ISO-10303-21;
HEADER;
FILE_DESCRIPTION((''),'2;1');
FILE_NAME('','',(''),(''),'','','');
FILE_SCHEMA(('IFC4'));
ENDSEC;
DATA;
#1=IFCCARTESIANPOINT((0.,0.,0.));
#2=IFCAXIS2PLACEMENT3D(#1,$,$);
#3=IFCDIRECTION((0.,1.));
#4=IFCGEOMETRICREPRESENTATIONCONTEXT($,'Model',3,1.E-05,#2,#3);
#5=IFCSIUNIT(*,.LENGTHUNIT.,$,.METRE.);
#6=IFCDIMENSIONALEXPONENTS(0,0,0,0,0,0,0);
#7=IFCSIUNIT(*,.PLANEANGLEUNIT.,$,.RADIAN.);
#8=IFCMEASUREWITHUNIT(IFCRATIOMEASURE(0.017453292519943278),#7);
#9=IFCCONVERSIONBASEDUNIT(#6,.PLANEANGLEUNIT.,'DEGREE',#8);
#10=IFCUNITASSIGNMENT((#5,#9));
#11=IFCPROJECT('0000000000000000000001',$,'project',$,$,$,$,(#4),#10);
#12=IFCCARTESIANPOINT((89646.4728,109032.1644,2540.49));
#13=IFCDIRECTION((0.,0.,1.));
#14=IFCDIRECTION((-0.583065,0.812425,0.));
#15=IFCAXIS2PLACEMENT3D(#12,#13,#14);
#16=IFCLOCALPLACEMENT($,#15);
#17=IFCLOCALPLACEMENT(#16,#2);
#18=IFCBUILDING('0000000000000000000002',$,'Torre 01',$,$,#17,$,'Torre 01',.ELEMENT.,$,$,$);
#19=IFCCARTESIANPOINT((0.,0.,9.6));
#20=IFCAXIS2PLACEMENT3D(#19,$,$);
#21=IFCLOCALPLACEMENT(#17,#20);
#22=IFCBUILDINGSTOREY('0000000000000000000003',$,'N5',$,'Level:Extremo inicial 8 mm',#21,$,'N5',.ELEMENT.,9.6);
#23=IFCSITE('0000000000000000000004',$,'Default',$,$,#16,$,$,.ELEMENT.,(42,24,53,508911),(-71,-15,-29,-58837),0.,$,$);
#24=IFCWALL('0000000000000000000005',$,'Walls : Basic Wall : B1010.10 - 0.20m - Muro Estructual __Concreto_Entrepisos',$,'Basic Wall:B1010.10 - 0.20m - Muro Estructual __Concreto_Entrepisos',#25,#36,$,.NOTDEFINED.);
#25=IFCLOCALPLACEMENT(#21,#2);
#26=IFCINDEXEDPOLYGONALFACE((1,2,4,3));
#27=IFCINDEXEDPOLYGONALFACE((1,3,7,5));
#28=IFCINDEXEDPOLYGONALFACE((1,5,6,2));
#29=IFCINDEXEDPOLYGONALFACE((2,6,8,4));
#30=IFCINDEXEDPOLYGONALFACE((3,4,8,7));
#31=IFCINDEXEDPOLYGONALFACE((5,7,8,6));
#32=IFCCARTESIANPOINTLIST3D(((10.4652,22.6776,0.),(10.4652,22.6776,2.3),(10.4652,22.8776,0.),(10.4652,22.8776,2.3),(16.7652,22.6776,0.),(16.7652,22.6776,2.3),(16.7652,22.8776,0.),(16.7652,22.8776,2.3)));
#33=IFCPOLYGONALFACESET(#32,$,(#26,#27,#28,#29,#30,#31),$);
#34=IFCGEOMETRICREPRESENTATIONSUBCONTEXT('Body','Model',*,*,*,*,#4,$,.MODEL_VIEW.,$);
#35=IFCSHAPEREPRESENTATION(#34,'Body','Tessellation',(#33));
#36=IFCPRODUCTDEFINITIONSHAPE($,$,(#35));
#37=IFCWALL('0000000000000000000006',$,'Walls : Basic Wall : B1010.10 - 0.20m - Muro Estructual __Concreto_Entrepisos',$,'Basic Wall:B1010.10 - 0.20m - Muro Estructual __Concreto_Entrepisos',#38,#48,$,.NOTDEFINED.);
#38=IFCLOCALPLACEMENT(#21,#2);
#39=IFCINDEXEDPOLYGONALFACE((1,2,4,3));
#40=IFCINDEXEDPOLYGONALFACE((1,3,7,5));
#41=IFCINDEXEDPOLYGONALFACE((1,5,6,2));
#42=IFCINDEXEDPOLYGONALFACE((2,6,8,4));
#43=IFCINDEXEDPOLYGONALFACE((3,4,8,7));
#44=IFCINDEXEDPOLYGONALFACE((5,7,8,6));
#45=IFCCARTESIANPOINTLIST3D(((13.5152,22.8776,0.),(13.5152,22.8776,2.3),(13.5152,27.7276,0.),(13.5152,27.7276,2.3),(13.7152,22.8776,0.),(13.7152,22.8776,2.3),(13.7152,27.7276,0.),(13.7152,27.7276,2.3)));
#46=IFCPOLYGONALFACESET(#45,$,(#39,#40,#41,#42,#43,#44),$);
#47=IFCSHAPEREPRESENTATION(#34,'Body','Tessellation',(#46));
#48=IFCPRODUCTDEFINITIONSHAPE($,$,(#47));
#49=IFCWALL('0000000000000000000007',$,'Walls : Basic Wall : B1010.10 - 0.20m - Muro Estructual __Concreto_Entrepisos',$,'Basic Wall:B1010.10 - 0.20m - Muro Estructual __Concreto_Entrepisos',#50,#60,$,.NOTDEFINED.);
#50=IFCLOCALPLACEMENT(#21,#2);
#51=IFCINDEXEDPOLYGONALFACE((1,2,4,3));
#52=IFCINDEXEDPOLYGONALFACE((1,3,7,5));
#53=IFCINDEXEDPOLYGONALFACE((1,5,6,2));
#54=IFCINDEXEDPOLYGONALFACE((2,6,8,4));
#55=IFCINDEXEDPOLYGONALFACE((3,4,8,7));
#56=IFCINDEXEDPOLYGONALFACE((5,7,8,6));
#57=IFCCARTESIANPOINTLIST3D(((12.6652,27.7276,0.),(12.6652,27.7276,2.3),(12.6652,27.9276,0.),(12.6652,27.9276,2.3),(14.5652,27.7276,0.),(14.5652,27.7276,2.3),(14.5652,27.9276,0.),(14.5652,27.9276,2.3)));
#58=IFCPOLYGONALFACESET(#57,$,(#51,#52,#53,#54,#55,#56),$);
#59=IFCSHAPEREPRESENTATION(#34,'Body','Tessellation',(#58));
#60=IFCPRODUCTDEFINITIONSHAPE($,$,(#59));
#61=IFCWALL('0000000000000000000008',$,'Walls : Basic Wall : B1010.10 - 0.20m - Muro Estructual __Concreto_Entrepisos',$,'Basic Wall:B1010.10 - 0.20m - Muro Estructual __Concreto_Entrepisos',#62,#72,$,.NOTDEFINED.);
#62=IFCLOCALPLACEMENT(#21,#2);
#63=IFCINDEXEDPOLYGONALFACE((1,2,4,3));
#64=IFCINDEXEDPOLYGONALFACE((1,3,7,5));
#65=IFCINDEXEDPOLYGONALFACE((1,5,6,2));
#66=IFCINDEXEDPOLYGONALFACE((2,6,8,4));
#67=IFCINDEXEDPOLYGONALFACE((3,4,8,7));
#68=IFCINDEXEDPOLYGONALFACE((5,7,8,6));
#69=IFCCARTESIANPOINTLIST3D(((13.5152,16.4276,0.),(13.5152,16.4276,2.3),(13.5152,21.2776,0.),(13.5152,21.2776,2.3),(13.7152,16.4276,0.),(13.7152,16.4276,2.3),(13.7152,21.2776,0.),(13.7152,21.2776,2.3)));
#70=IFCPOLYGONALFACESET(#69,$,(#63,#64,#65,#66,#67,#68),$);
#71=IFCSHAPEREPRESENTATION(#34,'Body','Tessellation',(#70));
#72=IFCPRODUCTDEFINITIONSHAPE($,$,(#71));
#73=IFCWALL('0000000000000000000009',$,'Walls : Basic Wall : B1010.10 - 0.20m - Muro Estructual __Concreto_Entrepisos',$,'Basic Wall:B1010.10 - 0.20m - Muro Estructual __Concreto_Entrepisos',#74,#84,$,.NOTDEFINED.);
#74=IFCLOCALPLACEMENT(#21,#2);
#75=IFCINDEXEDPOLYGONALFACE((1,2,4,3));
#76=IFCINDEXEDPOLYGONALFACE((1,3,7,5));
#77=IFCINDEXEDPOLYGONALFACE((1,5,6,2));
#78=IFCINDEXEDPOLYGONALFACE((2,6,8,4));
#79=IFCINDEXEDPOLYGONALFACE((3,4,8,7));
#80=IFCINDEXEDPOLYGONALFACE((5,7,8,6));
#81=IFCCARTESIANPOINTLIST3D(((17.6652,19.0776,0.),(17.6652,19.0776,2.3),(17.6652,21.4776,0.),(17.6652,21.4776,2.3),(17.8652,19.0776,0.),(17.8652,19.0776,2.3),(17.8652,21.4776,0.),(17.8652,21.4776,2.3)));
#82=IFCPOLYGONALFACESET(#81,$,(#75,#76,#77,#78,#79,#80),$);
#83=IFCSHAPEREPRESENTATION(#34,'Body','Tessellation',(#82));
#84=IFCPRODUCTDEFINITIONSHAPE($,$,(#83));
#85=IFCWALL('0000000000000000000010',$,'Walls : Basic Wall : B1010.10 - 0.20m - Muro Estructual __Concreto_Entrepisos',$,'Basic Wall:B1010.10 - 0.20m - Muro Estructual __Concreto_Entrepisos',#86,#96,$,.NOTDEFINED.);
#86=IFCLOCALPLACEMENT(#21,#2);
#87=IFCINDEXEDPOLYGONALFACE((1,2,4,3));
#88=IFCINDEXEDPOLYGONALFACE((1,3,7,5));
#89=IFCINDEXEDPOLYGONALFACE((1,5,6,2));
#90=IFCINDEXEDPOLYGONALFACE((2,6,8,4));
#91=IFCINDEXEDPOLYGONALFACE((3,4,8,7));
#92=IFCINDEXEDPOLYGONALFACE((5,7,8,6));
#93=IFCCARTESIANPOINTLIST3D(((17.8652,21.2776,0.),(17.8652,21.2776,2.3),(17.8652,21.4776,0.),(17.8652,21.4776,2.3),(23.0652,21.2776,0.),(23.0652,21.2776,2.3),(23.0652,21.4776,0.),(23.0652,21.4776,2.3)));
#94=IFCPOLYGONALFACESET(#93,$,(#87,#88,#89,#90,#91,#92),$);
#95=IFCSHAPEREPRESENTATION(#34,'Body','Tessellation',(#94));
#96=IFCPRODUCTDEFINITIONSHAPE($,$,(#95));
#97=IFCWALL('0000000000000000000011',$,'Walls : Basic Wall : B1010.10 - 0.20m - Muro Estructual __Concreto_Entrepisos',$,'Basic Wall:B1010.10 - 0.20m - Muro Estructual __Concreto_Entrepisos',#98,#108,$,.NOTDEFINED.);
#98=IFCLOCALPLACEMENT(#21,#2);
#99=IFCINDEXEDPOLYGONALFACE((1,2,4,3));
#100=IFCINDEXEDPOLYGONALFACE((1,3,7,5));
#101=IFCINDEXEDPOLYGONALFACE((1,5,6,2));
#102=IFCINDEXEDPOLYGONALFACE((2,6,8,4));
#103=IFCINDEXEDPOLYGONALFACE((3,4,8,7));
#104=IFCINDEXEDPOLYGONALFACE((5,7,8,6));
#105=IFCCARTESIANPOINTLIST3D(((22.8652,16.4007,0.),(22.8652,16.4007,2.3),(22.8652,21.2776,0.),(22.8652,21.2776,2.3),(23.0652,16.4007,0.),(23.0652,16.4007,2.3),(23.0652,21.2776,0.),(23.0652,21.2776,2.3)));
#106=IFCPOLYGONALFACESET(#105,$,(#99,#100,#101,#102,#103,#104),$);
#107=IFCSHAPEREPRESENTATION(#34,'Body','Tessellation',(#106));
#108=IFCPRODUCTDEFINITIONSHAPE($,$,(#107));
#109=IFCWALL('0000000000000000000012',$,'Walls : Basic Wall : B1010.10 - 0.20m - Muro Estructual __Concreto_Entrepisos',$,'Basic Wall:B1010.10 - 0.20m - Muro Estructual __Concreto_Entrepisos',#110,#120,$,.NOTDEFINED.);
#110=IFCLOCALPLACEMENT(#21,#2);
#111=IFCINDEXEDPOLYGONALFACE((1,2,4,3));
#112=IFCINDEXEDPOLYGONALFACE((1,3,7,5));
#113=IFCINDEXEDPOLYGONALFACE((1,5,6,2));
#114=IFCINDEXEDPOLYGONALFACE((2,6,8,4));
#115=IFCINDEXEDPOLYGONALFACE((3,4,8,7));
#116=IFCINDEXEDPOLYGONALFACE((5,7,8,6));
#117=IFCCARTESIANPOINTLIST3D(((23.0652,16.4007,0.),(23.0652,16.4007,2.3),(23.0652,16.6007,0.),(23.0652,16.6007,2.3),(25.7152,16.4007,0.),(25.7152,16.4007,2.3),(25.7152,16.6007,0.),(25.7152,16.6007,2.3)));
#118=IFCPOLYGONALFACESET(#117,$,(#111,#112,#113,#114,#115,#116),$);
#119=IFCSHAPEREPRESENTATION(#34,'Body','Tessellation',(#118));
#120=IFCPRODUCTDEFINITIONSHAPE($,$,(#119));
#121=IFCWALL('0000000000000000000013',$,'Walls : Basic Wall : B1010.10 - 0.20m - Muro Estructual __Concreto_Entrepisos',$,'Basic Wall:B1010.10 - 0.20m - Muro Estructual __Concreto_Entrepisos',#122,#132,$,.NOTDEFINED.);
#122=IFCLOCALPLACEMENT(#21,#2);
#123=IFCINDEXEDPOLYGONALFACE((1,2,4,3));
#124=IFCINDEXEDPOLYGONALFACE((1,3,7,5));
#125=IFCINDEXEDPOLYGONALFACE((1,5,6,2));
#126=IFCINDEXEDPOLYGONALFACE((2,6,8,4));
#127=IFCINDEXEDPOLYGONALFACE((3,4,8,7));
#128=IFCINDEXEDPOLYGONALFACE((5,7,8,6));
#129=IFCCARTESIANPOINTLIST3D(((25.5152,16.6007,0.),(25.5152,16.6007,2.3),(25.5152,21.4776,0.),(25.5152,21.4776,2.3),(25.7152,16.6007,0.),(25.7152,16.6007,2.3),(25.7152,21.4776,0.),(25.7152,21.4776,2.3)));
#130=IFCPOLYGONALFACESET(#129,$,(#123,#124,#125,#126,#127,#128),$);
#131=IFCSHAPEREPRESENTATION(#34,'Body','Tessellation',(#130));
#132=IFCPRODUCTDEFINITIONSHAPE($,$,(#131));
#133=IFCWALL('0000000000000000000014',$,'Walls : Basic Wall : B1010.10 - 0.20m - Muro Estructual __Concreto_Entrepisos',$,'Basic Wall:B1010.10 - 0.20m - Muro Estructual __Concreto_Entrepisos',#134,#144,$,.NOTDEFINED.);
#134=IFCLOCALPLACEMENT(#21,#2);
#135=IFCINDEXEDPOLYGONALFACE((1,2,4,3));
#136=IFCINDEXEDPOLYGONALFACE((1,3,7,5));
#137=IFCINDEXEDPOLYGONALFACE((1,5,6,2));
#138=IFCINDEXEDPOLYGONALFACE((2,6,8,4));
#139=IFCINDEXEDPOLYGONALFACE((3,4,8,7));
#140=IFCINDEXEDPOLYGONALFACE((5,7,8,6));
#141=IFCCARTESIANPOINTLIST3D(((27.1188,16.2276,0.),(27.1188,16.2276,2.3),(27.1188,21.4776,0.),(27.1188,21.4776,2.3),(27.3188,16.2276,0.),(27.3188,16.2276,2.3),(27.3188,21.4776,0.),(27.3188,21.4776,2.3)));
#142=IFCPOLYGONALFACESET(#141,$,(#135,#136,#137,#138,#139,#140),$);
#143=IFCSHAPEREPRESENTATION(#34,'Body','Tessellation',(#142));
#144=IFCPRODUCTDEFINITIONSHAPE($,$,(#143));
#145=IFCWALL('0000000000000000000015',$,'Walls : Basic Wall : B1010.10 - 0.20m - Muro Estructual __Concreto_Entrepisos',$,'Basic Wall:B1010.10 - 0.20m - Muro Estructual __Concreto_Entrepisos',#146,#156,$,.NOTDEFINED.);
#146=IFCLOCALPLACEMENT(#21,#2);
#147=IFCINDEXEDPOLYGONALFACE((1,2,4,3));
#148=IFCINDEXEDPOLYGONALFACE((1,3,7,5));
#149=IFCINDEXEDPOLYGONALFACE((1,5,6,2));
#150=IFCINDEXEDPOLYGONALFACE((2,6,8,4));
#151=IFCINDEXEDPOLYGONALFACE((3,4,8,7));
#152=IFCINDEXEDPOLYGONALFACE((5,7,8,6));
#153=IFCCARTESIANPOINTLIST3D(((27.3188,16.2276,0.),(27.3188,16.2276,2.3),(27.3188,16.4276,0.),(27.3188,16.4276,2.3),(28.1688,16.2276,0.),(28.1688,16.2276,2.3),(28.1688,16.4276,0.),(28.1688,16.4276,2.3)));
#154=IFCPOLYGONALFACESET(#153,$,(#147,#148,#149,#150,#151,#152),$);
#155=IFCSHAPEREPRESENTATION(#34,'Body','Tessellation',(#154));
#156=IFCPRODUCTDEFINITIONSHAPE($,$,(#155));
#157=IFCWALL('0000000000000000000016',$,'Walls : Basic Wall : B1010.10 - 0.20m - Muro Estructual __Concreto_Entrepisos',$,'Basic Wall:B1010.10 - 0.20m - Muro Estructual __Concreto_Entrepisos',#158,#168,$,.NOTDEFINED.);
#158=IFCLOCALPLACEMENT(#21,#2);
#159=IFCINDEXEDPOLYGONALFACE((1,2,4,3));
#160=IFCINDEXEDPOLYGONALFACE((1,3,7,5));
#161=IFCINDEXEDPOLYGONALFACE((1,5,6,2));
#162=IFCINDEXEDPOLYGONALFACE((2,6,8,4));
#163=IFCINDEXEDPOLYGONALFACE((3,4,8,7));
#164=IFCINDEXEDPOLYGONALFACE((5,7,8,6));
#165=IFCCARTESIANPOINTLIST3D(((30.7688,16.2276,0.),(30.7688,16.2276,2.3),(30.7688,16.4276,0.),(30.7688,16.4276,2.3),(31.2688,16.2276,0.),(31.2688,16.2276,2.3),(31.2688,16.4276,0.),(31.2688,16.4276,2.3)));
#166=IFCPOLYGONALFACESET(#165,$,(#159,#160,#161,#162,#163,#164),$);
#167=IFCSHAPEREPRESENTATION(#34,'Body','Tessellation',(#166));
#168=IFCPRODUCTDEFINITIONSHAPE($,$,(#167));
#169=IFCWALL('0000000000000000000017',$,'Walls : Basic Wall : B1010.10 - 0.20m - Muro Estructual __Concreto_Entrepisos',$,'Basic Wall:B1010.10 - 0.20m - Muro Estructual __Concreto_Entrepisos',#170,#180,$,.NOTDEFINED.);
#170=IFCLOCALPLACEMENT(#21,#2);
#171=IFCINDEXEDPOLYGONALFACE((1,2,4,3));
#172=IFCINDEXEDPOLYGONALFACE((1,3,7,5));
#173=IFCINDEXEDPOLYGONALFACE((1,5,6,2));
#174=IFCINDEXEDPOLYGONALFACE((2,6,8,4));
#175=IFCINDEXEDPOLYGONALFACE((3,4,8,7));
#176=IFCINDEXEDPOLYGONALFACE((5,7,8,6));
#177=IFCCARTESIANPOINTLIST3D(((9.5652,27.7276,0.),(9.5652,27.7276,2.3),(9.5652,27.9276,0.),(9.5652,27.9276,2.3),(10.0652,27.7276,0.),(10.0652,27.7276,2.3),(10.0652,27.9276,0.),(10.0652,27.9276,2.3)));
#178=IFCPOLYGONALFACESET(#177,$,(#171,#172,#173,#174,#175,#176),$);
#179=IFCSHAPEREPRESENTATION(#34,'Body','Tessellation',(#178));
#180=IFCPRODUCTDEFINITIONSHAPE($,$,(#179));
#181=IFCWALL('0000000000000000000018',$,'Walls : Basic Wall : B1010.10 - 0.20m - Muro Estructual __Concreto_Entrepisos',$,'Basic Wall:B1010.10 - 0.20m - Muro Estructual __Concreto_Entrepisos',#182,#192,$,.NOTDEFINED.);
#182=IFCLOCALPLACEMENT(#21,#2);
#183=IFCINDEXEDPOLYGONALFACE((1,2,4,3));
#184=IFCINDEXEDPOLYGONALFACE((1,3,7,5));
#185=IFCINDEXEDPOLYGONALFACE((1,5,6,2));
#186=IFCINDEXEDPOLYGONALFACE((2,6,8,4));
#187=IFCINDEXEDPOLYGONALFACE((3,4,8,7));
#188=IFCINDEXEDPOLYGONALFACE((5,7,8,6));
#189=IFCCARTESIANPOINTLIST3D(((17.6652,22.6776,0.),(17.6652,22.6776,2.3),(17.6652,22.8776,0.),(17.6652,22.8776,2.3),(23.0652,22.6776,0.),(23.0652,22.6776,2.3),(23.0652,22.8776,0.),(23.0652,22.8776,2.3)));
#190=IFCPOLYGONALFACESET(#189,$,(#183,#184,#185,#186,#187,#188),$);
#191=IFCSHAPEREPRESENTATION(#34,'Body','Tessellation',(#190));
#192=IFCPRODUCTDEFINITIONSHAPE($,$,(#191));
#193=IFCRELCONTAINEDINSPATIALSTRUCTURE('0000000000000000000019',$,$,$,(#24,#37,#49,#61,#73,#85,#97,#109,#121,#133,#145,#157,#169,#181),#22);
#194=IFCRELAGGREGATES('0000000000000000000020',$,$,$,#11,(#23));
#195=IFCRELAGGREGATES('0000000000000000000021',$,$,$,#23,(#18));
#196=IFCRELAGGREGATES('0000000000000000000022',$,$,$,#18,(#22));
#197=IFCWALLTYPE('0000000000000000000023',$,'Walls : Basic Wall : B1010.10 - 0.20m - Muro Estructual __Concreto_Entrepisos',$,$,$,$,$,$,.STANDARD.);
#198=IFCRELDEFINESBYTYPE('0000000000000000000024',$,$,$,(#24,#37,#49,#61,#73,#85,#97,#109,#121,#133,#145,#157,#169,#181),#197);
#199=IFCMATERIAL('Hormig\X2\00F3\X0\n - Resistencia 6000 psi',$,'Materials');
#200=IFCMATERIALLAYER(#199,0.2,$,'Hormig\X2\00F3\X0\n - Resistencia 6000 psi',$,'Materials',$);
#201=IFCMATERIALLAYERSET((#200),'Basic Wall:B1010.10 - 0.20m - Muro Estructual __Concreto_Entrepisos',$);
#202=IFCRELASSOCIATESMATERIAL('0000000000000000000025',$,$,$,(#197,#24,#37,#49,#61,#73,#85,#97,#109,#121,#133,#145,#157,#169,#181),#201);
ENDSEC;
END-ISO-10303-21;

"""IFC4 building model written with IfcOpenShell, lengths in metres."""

from ifc_helpers import new_model, entity, si_unit, converted_unit, direction, frame, frame_2d, origin, place, context, subcontext, project, spatial, rectangle, extrude, material, layer, layer_set, layer_usage, type_object, element, save


model = new_model("IFC4")

# Units and contexts
model_context = context("Model", 3, precision=1e-05, world=origin(), true_north=direction((0.0, 1.0)))
body_context = subcontext(model_context, "Body", "Model", "MODEL_VIEW")
ifc_project = project(units=[si_unit("LENGTHUNIT", "METRE"), converted_unit("PLANEANGLEUNIT", "DEGREE", entity("IfcRatioMeasure", 0.017453292519943278), si_unit("PLANEANGLEUNIT", "RADIAN"), dimensions=[0, 0, 0, 0, 0, 0, 0])], contexts=[model_context])

# Site, building, storey
site_placement = place(None, frame((89646.4728, 109032.1644, 2540.49), z_axis=(0.0, 0.0, 1.0), x_axis=(-0.583065, 0.812425, 0.0)))
site = spatial("IfcSite", under=ifc_project, at=site_placement, Name="Default", CompositionType="ELEMENT", RefLatitude=(42, 24, 53, 508911), RefLongitude=(-71, -15, -29, -58837), RefElevation=0.0)
building_placement = place(site_placement, origin())
building = spatial("IfcBuilding", under=site, at=building_placement, Name="Torre 01", LongName="Torre 01", CompositionType="ELEMENT")
storey_placement = place(building_placement, frame((0.0, 0.0, 9.6)))
storey = spatial("IfcBuildingStorey", under=building, at=storey_placement, Name="N5", ObjectType="Level:Extremo inicial 8 mm", LongName="N5", CompositionType="ELEMENT", Elevation=9.6)

# Walls
ifc_material = material(Name="Hormigón - Resistencia 6000 psi", Category="Materials")
ifc_layer_1 = layer(ifc_material, 0.2, Name="Hormigón - Resistencia 6000 psi", Category="Materials")
ifc_layer_set_1 = layer_set([ifc_layer_1], Name="Basic Wall:B1010.10 - 0.20m - Muro Estructual __Concreto_Entrepisos")
ifc_layer_usage_1 = layer_usage(ifc_layer_set_1, "AXIS2", "NEGATIVE", 0.1)
wall_type_1 = type_object("IfcWallType", Name="Walls : Basic Wall : B1010.10 - 0.20m - Muro Estructual __Concreto_Entrepisos", PredefinedType="STANDARD", material=ifc_layer_set_1)
wall_1_placement = place(storey_placement, frame((10.4652, 22.7776, 0.0)))
element("IfcWall", 1, at=wall_1_placement, inside=storey, type_object=wall_type_1, material=ifc_layer_usage_1, Name="Walls : Basic Wall : B1010.10 - 0.20m - Muro Estructual __Concreto_Entrepisos", ObjectType="Basic Wall:B1010.10 - 0.20m - Muro Estructual __Concreto_Entrepisos", PredefinedType="NOTDEFINED", context=body_context, shape_type="SweptSolid", body=[
    extrude(rectangle(XDim=6.3, YDim=0.2, at=frame_2d((3.15, 0.0), x_axis=(-1.0, 0.0))), origin(), (0.0, 0.0, 1.0), 2.3),
])
ifc_layer_usage_2 = layer_usage(ifc_layer_set_1, "AXIS2", "NEGATIVE", 0.1)
wall_2_placement = place(storey_placement, frame((13.6152, 22.8776, 0.0), z_axis=(0.0, 0.0, 1.0), x_axis=(0.0, 1.0, 0.0)))
element("IfcWall", 2, at=wall_2_placement, inside=storey, type_object=wall_type_1, material=ifc_layer_usage_2, Name="Walls : Basic Wall : B1010.10 - 0.20m - Muro Estructual __Concreto_Entrepisos", ObjectType="Basic Wall:B1010.10 - 0.20m - Muro Estructual __Concreto_Entrepisos", PredefinedType="NOTDEFINED", context=body_context, shape_type="SweptSolid", body=[
    extrude(rectangle(XDim=4.85, YDim=0.2, at=frame_2d((2.425, 0.0), x_axis=(-1.0, 0.0))), origin(), (0.0, 0.0, 1.0), 2.3),
])
ifc_layer_usage_3 = layer_usage(ifc_layer_set_1, "AXIS2", "NEGATIVE", 0.1)
wall_3_placement = place(storey_placement, frame((12.6652, 27.8276, 0.0)))
element("IfcWall", 3, at=wall_3_placement, inside=storey, type_object=wall_type_1, material=ifc_layer_usage_3, Name="Walls : Basic Wall : B1010.10 - 0.20m - Muro Estructual __Concreto_Entrepisos", ObjectType="Basic Wall:B1010.10 - 0.20m - Muro Estructual __Concreto_Entrepisos", PredefinedType="NOTDEFINED", context=body_context, shape_type="SweptSolid", body=[
    extrude(rectangle(XDim=1.9, YDim=0.2, at=frame_2d((0.95, 0.0), x_axis=(-1.0, 0.0))), origin(), (0.0, 0.0, 1.0), 2.3),
])
ifc_layer_usage_4 = layer_usage(ifc_layer_set_1, "AXIS2", "NEGATIVE", 0.1)
wall_4_placement = place(storey_placement, frame((13.6152, 21.2776, 0.0), z_axis=(0.0, 0.0, 1.0), x_axis=(0.0, -1.0, 0.0)))
element("IfcWall", 4, at=wall_4_placement, inside=storey, type_object=wall_type_1, material=ifc_layer_usage_4, Name="Walls : Basic Wall : B1010.10 - 0.20m - Muro Estructual __Concreto_Entrepisos", ObjectType="Basic Wall:B1010.10 - 0.20m - Muro Estructual __Concreto_Entrepisos", PredefinedType="NOTDEFINED", context=body_context, shape_type="SweptSolid", body=[
    extrude(rectangle(XDim=4.85, YDim=0.2, at=frame_2d((2.425, 0.0), x_axis=(-1.0, 0.0))), origin(), (0.0, 0.0, 1.0), 2.3),
])
ifc_layer_usage_5 = layer_usage(ifc_layer_set_1, "AXIS2", "NEGATIVE", 0.1)
wall_5_placement = place(storey_placement, frame((17.7652, 19.0776, 0.0), z_axis=(0.0, 0.0, 1.0), x_axis=(0.0, 1.0, 0.0)))
element("IfcWall", 5, at=wall_5_placement, inside=storey, type_object=wall_type_1, material=ifc_layer_usage_5, Name="Walls : Basic Wall : B1010.10 - 0.20m - Muro Estructual __Concreto_Entrepisos", ObjectType="Basic Wall:B1010.10 - 0.20m - Muro Estructual __Concreto_Entrepisos", PredefinedType="NOTDEFINED", context=body_context, shape_type="SweptSolid", body=[
    extrude(rectangle(XDim=2.4, YDim=0.2, at=frame_2d((1.2, 0.0), x_axis=(-1.0, 0.0))), origin(), (0.0, 0.0, 1.0), 2.3),
])
ifc_layer_usage_6 = layer_usage(ifc_layer_set_1, "AXIS2", "NEGATIVE", 0.1)
wall_6_placement = place(storey_placement, frame((17.8652, 21.3776, 0.0)))
element("IfcWall", 6, at=wall_6_placement, inside=storey, type_object=wall_type_1, material=ifc_layer_usage_6, Name="Walls : Basic Wall : B1010.10 - 0.20m - Muro Estructual __Concreto_Entrepisos", ObjectType="Basic Wall:B1010.10 - 0.20m - Muro Estructual __Concreto_Entrepisos", PredefinedType="NOTDEFINED", context=body_context, shape_type="SweptSolid", body=[
    extrude(rectangle(XDim=5.2, YDim=0.2, at=frame_2d((2.6, 0.0), x_axis=(-1.0, 0.0))), origin(), (0.0, 0.0, 1.0), 2.3),
])
ifc_layer_usage_7 = layer_usage(ifc_layer_set_1, "AXIS2", "NEGATIVE", 0.1)
wall_7_placement = place(storey_placement, frame((22.9652, 21.2776, 0.0), z_axis=(0.0, 0.0, 1.0), x_axis=(0.0, -1.0, 0.0)))
element("IfcWall", 7, at=wall_7_placement, inside=storey, type_object=wall_type_1, material=ifc_layer_usage_7, Name="Walls : Basic Wall : B1010.10 - 0.20m - Muro Estructual __Concreto_Entrepisos", ObjectType="Basic Wall:B1010.10 - 0.20m - Muro Estructual __Concreto_Entrepisos", PredefinedType="NOTDEFINED", context=body_context, shape_type="SweptSolid", body=[
    extrude(rectangle(XDim=4.8769, YDim=0.2, at=frame_2d((2.4384, 0.0), x_axis=(-1.0, 0.0))), origin(), (0.0, 0.0, 1.0), 2.3),
])
ifc_layer_usage_8 = layer_usage(ifc_layer_set_1, "AXIS2", "NEGATIVE", 0.1)
wall_8_placement = place(storey_placement, frame((23.0652, 16.5007, 0.0)))
element("IfcWall", 8, at=wall_8_placement, inside=storey, type_object=wall_type_1, material=ifc_layer_usage_8, Name="Walls : Basic Wall : B1010.10 - 0.20m - Muro Estructual __Concreto_Entrepisos", ObjectType="Basic Wall:B1010.10 - 0.20m - Muro Estructual __Concreto_Entrepisos", PredefinedType="NOTDEFINED", context=body_context, shape_type="SweptSolid", body=[
    extrude(rectangle(XDim=2.65, YDim=0.2, at=frame_2d((1.325, 0.0), x_axis=(-1.0, 0.0))), origin(), (0.0, 0.0, 1.0), 2.3),
])
ifc_layer_usage_9 = layer_usage(ifc_layer_set_1, "AXIS2", "NEGATIVE", 0.1)
wall_9_placement = place(storey_placement, frame((25.6152, 16.6007, 0.0), z_axis=(0.0, 0.0, 1.0), x_axis=(0.0, 1.0, 0.0)))
element("IfcWall", 9, at=wall_9_placement, inside=storey, type_object=wall_type_1, material=ifc_layer_usage_9, Name="Walls : Basic Wall : B1010.10 - 0.20m - Muro Estructual __Concreto_Entrepisos", ObjectType="Basic Wall:B1010.10 - 0.20m - Muro Estructual __Concreto_Entrepisos", PredefinedType="NOTDEFINED", context=body_context, shape_type="SweptSolid", body=[
    extrude(rectangle(XDim=4.8769, YDim=0.2, at=frame_2d((2.4384, 0.0), x_axis=(-1.0, 0.0))), origin(), (0.0, 0.0, 1.0), 2.3),
])
ifc_layer_usage_10 = layer_usage(ifc_layer_set_1, "AXIS2", "NEGATIVE", 0.1)
wall_10_placement = place(storey_placement, frame((27.2188, 16.2276, 0.0), z_axis=(0.0, 0.0, 1.0), x_axis=(0.0, 1.0, 0.0)))
element("IfcWall", 10, at=wall_10_placement, inside=storey, type_object=wall_type_1, material=ifc_layer_usage_10, Name="Walls : Basic Wall : B1010.10 - 0.20m - Muro Estructual __Concreto_Entrepisos", ObjectType="Basic Wall:B1010.10 - 0.20m - Muro Estructual __Concreto_Entrepisos", PredefinedType="NOTDEFINED", context=body_context, shape_type="SweptSolid", body=[
    extrude(rectangle(XDim=5.25, YDim=0.2, at=frame_2d((2.625, 0.0), x_axis=(-1.0, 0.0))), origin(), (0.0, 0.0, 1.0), 2.3),
])
ifc_layer_usage_11 = layer_usage(ifc_layer_set_1, "AXIS2", "NEGATIVE", 0.1)
wall_11_placement = place(storey_placement, frame((27.3188, 16.3276, 0.0)))
element("IfcWall", 11, at=wall_11_placement, inside=storey, type_object=wall_type_1, material=ifc_layer_usage_11, Name="Walls : Basic Wall : B1010.10 - 0.20m - Muro Estructual __Concreto_Entrepisos", ObjectType="Basic Wall:B1010.10 - 0.20m - Muro Estructual __Concreto_Entrepisos", PredefinedType="NOTDEFINED", context=body_context, shape_type="SweptSolid", body=[
    extrude(rectangle(XDim=0.85, YDim=0.2, at=frame_2d((0.425, 0.0), x_axis=(-1.0, 0.0))), origin(), (0.0, 0.0, 1.0), 2.3),
])
ifc_layer_usage_12 = layer_usage(ifc_layer_set_1, "AXIS2", "NEGATIVE", 0.1)
wall_12_placement = place(storey_placement, frame((30.7688, 16.3276, 0.0)))
element("IfcWall", 12, at=wall_12_placement, inside=storey, type_object=wall_type_1, material=ifc_layer_usage_12, Name="Walls : Basic Wall : B1010.10 - 0.20m - Muro Estructual __Concreto_Entrepisos", ObjectType="Basic Wall:B1010.10 - 0.20m - Muro Estructual __Concreto_Entrepisos", PredefinedType="NOTDEFINED", context=body_context, shape_type="SweptSolid", body=[
    extrude(rectangle(XDim=0.5, YDim=0.2, at=frame_2d((0.25, 0.0), x_axis=(-1.0, 0.0))), origin(), (0.0, 0.0, 1.0), 2.3),
])
ifc_layer_usage_13 = layer_usage(ifc_layer_set_1, "AXIS2", "NEGATIVE", 0.1)
wall_13_placement = place(storey_placement, frame((9.5652, 27.8276, 0.0)))
element("IfcWall", 13, at=wall_13_placement, inside=storey, type_object=wall_type_1, material=ifc_layer_usage_13, Name="Walls : Basic Wall : B1010.10 - 0.20m - Muro Estructual __Concreto_Entrepisos", ObjectType="Basic Wall:B1010.10 - 0.20m - Muro Estructual __Concreto_Entrepisos", PredefinedType="NOTDEFINED", context=body_context, shape_type="SweptSolid", body=[
    extrude(rectangle(XDim=0.5, YDim=0.2, at=frame_2d((0.25, 0.0), x_axis=(-1.0, 0.0))), origin(), (0.0, 0.0, 1.0), 2.3),
])
ifc_layer_usage_14 = layer_usage(ifc_layer_set_1, "AXIS2", "NEGATIVE", 0.1)
wall_14_placement = place(storey_placement, frame((17.6652, 22.7776, 0.0)))
element("IfcWall", 14, at=wall_14_placement, inside=storey, type_object=wall_type_1, material=ifc_layer_usage_14, Name="Walls : Basic Wall : B1010.10 - 0.20m - Muro Estructual __Concreto_Entrepisos", ObjectType="Basic Wall:B1010.10 - 0.20m - Muro Estructual __Concreto_Entrepisos", PredefinedType="NOTDEFINED", context=body_context, shape_type="SweptSolid", body=[
    extrude(rectangle(XDim=5.4, YDim=0.2, at=frame_2d((2.7, 0.0), x_axis=(-1.0, 0.0))), origin(), (0.0, 0.0, 1.0), 2.3),
])

save(model, "model.ifc")
